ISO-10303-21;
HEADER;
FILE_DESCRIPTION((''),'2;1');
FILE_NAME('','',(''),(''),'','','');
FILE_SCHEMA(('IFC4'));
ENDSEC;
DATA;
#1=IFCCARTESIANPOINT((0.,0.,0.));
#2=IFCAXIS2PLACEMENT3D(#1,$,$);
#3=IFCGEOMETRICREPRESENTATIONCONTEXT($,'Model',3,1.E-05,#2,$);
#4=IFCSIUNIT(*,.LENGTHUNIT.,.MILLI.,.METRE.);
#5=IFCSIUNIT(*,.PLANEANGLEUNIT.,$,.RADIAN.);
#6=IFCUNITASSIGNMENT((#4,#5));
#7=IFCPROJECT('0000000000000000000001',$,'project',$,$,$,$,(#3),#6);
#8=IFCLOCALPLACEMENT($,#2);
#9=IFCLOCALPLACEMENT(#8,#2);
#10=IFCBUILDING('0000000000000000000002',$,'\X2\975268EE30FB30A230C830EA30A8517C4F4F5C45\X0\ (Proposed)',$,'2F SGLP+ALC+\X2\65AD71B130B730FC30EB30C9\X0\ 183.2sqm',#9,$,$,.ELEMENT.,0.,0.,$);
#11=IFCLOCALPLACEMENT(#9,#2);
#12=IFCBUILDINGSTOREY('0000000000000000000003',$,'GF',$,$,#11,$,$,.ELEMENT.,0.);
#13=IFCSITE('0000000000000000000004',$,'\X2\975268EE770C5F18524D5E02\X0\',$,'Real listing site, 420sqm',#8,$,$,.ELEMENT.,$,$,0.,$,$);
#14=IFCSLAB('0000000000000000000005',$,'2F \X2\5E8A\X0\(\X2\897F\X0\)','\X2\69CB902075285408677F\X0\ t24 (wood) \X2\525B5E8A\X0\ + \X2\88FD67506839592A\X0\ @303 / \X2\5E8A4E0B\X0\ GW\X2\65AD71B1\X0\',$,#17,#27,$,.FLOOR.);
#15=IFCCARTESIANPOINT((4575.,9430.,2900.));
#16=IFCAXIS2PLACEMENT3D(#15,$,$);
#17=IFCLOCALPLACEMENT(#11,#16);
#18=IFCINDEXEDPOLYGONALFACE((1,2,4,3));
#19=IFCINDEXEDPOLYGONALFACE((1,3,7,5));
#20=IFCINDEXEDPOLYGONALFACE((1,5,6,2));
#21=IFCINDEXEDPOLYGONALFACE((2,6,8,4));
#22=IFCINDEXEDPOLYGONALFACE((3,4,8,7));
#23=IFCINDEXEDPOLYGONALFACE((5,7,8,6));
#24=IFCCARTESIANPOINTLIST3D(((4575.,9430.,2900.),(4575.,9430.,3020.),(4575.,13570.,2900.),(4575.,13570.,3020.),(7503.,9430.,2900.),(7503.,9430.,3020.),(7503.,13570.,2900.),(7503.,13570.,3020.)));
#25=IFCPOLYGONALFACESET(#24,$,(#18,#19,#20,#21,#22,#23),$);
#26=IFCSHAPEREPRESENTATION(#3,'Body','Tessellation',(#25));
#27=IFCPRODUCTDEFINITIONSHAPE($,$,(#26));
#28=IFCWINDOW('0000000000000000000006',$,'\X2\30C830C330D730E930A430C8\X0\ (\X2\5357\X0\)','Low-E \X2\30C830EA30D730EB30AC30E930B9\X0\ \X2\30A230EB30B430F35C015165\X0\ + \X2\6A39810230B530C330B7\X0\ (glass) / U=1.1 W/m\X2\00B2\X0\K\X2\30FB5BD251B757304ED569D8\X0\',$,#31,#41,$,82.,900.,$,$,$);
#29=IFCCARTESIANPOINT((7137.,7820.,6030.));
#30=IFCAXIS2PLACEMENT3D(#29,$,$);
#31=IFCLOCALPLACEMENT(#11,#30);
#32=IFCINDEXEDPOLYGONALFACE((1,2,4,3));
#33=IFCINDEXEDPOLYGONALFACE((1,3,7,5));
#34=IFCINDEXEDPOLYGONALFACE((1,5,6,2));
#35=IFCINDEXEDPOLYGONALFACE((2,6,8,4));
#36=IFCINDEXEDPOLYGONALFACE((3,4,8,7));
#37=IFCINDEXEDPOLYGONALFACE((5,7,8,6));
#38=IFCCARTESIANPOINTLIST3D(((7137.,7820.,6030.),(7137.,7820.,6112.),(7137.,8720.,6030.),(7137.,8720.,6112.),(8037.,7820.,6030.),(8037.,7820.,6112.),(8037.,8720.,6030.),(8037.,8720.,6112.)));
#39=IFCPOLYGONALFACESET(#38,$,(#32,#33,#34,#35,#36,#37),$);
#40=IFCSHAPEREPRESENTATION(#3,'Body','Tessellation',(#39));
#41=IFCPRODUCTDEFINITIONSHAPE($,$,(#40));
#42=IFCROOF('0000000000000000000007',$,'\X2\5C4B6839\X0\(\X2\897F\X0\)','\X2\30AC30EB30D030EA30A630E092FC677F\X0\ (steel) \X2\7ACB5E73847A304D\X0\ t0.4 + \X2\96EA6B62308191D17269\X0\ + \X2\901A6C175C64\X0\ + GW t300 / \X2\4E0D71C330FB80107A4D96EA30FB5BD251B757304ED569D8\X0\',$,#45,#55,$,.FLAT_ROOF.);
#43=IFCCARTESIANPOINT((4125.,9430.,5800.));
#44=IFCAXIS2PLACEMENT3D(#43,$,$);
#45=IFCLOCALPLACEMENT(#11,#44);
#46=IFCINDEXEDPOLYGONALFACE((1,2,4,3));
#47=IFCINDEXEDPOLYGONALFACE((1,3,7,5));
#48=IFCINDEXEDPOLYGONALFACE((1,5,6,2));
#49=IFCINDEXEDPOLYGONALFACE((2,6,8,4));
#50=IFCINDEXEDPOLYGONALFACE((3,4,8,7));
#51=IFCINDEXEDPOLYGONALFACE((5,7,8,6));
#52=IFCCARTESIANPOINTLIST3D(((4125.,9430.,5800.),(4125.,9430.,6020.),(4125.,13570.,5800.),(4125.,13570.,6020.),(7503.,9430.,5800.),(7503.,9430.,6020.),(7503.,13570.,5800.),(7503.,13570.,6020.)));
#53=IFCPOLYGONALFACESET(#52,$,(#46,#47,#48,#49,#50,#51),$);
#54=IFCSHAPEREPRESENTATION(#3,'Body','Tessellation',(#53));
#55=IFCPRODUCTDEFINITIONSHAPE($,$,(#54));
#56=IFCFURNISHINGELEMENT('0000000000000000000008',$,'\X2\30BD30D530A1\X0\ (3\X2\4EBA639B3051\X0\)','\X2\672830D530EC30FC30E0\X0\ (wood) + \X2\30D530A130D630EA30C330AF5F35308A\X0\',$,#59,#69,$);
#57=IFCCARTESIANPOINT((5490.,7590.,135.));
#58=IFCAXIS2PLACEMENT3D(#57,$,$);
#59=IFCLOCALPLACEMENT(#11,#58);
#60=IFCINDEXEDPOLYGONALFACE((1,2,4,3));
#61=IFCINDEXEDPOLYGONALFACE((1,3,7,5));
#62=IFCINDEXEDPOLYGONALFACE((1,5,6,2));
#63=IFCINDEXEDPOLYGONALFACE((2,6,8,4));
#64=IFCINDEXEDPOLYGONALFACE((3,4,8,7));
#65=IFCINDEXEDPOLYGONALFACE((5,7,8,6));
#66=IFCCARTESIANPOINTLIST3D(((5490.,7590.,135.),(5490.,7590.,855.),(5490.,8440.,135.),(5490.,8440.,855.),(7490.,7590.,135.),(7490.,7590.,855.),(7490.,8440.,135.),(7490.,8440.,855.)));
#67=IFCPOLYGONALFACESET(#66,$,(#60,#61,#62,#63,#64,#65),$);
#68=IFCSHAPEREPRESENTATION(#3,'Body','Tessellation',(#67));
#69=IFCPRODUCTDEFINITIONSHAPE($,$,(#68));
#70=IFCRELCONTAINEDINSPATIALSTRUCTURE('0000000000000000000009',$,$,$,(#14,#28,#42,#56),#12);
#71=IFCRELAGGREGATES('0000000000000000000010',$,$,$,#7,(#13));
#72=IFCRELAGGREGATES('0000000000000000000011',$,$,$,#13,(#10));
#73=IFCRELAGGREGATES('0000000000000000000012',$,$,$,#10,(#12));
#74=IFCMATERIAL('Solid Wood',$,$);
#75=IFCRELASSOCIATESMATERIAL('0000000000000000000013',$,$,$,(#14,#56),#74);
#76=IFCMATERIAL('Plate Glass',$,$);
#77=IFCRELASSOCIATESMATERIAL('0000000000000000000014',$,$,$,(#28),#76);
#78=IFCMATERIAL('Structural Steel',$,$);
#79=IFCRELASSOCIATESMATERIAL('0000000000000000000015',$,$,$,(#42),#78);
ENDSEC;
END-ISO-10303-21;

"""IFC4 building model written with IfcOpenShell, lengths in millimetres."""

from ifc_helpers import new_model, si_unit, frame, frame_2d, origin, place, context, project, spatial, rectangle, extrude, material, element, save


model = new_model("IFC4")

# Units and contexts
model_context = context("Model", 3, precision=1e-05, world=origin())
ifc_project = project(units=[si_unit("LENGTHUNIT", "METRE", prefix="MILLI"), si_unit("PLANEANGLEUNIT", "RADIAN")], contexts=[model_context])

# Site, building, storey
site_placement = place(None, origin())
site = spatial("IfcSite", under=ifc_project, at=site_placement, Name="青森県弘前市", ObjectType="Real listing site, 420sqm", CompositionType="ELEMENT", RefElevation=0.0)
building_placement = place(site_placement, origin())
building = spatial("IfcBuilding", under=site, at=building_placement, Name="青森・アトリエ兼住居 (Proposed)", ObjectType="2F SGLP+ALC+断熱シールド 183.2sqm", CompositionType="ELEMENT", ElevationOfRefHeight=0.0, ElevationOfTerrain=0.0)
storey_placement = place(building_placement, origin())
storey = spatial("IfcBuildingStorey", under=building, at=storey_placement, Name="GF", CompositionType="ELEMENT", Elevation=0.0)

# Shared definitions
ifc_material_1 = material(Name="Solid Wood")

# Slab
slab_1_placement = place(storey_placement, frame((4575.0, 9430.0, 2900.0)))
element("IfcSlab", 1, at=slab_1_placement, inside=storey, material=ifc_material_1, Name="2F 床(西)", Description="構造用合板 t24 (wood) 剛床 + 製材根太 @303 / 床下 GW断熱", PredefinedType="FLOOR", context=model_context, shape_type="SweptSolid", body=[
    extrude(rectangle(XDim=2928.0, YDim=4140.0, at=frame_2d((1464.0, 2070.0))), frame((4575.0, 9430.0, 2900.0)), (0.0, 0.0, 1.0), 120.0),
])

# Window
ifc_material_2 = material(Name="Plate Glass")
window_placement = place(storey_placement, frame((7137.0, 7820.0, 6030.0)))
element("IfcWindow", 2, at=window_placement, inside=storey, material=ifc_material_2, Name="トップライト (南)", Description="Low-E トリプルガラス アルゴン封入 + 樹脂サッシ (glass) / U=1.1 W/m²K・寒冷地仕様", OverallHeight=82.0, OverallWidth=900.0, context=model_context, shape_type="SweptSolid", body=[
    extrude(rectangle(XDim=900.0, YDim=900.0, at=frame_2d((450.0, 450.0))), frame((7137.0, 7820.0, 6030.0)), (0.0, 0.0, 1.0), 82.0),
])

# Roof
ifc_material_3 = material(Name="Structural Steel")
for number, where, name in (
    (3, (4125.0, 9430.0, 5800.0), "屋根(西)"),
):
    element("IfcRoof", number, at=place(storey_placement, frame(where)), inside=storey, material=ifc_material_3, Name=name, Description="ガルバリウム鋼板 (steel) 立平葺き t0.4 + 雪止め金物 + 通気層 + GW t300 / 不燃・耐積雪・寒冷地仕様", PredefinedType="FLAT_ROOF", context=model_context, shape_type="SweptSolid", body=[
        extrude(rectangle(XDim=3378.0, YDim=4140.0, at=frame_2d((1689.0, 2070.0))), frame((4125.0, 9430.0, 5800.0)), (0.0, 0.0, 1.0), 220.0),
    ])

# Furnishing element
furnishing_placement = place(storey_placement, frame((5490.0, 7590.0, 135.0)))
element("IfcFurnishingElement", 4, at=furnishing_placement, inside=storey, material=ifc_material_1, Name="ソファ (3人掛け)", Description="木フレーム (wood) + ファブリック張り", context=model_context, shape_type="SweptSolid", body=[
    extrude(rectangle(XDim=2000.0, YDim=850.0, at=frame_2d((1000.0, 425.0))), frame((5490.0, 7590.0, 135.0)), (0.0, 0.0, 1.0), 720.0),
])

save(model, "model.ifc")
